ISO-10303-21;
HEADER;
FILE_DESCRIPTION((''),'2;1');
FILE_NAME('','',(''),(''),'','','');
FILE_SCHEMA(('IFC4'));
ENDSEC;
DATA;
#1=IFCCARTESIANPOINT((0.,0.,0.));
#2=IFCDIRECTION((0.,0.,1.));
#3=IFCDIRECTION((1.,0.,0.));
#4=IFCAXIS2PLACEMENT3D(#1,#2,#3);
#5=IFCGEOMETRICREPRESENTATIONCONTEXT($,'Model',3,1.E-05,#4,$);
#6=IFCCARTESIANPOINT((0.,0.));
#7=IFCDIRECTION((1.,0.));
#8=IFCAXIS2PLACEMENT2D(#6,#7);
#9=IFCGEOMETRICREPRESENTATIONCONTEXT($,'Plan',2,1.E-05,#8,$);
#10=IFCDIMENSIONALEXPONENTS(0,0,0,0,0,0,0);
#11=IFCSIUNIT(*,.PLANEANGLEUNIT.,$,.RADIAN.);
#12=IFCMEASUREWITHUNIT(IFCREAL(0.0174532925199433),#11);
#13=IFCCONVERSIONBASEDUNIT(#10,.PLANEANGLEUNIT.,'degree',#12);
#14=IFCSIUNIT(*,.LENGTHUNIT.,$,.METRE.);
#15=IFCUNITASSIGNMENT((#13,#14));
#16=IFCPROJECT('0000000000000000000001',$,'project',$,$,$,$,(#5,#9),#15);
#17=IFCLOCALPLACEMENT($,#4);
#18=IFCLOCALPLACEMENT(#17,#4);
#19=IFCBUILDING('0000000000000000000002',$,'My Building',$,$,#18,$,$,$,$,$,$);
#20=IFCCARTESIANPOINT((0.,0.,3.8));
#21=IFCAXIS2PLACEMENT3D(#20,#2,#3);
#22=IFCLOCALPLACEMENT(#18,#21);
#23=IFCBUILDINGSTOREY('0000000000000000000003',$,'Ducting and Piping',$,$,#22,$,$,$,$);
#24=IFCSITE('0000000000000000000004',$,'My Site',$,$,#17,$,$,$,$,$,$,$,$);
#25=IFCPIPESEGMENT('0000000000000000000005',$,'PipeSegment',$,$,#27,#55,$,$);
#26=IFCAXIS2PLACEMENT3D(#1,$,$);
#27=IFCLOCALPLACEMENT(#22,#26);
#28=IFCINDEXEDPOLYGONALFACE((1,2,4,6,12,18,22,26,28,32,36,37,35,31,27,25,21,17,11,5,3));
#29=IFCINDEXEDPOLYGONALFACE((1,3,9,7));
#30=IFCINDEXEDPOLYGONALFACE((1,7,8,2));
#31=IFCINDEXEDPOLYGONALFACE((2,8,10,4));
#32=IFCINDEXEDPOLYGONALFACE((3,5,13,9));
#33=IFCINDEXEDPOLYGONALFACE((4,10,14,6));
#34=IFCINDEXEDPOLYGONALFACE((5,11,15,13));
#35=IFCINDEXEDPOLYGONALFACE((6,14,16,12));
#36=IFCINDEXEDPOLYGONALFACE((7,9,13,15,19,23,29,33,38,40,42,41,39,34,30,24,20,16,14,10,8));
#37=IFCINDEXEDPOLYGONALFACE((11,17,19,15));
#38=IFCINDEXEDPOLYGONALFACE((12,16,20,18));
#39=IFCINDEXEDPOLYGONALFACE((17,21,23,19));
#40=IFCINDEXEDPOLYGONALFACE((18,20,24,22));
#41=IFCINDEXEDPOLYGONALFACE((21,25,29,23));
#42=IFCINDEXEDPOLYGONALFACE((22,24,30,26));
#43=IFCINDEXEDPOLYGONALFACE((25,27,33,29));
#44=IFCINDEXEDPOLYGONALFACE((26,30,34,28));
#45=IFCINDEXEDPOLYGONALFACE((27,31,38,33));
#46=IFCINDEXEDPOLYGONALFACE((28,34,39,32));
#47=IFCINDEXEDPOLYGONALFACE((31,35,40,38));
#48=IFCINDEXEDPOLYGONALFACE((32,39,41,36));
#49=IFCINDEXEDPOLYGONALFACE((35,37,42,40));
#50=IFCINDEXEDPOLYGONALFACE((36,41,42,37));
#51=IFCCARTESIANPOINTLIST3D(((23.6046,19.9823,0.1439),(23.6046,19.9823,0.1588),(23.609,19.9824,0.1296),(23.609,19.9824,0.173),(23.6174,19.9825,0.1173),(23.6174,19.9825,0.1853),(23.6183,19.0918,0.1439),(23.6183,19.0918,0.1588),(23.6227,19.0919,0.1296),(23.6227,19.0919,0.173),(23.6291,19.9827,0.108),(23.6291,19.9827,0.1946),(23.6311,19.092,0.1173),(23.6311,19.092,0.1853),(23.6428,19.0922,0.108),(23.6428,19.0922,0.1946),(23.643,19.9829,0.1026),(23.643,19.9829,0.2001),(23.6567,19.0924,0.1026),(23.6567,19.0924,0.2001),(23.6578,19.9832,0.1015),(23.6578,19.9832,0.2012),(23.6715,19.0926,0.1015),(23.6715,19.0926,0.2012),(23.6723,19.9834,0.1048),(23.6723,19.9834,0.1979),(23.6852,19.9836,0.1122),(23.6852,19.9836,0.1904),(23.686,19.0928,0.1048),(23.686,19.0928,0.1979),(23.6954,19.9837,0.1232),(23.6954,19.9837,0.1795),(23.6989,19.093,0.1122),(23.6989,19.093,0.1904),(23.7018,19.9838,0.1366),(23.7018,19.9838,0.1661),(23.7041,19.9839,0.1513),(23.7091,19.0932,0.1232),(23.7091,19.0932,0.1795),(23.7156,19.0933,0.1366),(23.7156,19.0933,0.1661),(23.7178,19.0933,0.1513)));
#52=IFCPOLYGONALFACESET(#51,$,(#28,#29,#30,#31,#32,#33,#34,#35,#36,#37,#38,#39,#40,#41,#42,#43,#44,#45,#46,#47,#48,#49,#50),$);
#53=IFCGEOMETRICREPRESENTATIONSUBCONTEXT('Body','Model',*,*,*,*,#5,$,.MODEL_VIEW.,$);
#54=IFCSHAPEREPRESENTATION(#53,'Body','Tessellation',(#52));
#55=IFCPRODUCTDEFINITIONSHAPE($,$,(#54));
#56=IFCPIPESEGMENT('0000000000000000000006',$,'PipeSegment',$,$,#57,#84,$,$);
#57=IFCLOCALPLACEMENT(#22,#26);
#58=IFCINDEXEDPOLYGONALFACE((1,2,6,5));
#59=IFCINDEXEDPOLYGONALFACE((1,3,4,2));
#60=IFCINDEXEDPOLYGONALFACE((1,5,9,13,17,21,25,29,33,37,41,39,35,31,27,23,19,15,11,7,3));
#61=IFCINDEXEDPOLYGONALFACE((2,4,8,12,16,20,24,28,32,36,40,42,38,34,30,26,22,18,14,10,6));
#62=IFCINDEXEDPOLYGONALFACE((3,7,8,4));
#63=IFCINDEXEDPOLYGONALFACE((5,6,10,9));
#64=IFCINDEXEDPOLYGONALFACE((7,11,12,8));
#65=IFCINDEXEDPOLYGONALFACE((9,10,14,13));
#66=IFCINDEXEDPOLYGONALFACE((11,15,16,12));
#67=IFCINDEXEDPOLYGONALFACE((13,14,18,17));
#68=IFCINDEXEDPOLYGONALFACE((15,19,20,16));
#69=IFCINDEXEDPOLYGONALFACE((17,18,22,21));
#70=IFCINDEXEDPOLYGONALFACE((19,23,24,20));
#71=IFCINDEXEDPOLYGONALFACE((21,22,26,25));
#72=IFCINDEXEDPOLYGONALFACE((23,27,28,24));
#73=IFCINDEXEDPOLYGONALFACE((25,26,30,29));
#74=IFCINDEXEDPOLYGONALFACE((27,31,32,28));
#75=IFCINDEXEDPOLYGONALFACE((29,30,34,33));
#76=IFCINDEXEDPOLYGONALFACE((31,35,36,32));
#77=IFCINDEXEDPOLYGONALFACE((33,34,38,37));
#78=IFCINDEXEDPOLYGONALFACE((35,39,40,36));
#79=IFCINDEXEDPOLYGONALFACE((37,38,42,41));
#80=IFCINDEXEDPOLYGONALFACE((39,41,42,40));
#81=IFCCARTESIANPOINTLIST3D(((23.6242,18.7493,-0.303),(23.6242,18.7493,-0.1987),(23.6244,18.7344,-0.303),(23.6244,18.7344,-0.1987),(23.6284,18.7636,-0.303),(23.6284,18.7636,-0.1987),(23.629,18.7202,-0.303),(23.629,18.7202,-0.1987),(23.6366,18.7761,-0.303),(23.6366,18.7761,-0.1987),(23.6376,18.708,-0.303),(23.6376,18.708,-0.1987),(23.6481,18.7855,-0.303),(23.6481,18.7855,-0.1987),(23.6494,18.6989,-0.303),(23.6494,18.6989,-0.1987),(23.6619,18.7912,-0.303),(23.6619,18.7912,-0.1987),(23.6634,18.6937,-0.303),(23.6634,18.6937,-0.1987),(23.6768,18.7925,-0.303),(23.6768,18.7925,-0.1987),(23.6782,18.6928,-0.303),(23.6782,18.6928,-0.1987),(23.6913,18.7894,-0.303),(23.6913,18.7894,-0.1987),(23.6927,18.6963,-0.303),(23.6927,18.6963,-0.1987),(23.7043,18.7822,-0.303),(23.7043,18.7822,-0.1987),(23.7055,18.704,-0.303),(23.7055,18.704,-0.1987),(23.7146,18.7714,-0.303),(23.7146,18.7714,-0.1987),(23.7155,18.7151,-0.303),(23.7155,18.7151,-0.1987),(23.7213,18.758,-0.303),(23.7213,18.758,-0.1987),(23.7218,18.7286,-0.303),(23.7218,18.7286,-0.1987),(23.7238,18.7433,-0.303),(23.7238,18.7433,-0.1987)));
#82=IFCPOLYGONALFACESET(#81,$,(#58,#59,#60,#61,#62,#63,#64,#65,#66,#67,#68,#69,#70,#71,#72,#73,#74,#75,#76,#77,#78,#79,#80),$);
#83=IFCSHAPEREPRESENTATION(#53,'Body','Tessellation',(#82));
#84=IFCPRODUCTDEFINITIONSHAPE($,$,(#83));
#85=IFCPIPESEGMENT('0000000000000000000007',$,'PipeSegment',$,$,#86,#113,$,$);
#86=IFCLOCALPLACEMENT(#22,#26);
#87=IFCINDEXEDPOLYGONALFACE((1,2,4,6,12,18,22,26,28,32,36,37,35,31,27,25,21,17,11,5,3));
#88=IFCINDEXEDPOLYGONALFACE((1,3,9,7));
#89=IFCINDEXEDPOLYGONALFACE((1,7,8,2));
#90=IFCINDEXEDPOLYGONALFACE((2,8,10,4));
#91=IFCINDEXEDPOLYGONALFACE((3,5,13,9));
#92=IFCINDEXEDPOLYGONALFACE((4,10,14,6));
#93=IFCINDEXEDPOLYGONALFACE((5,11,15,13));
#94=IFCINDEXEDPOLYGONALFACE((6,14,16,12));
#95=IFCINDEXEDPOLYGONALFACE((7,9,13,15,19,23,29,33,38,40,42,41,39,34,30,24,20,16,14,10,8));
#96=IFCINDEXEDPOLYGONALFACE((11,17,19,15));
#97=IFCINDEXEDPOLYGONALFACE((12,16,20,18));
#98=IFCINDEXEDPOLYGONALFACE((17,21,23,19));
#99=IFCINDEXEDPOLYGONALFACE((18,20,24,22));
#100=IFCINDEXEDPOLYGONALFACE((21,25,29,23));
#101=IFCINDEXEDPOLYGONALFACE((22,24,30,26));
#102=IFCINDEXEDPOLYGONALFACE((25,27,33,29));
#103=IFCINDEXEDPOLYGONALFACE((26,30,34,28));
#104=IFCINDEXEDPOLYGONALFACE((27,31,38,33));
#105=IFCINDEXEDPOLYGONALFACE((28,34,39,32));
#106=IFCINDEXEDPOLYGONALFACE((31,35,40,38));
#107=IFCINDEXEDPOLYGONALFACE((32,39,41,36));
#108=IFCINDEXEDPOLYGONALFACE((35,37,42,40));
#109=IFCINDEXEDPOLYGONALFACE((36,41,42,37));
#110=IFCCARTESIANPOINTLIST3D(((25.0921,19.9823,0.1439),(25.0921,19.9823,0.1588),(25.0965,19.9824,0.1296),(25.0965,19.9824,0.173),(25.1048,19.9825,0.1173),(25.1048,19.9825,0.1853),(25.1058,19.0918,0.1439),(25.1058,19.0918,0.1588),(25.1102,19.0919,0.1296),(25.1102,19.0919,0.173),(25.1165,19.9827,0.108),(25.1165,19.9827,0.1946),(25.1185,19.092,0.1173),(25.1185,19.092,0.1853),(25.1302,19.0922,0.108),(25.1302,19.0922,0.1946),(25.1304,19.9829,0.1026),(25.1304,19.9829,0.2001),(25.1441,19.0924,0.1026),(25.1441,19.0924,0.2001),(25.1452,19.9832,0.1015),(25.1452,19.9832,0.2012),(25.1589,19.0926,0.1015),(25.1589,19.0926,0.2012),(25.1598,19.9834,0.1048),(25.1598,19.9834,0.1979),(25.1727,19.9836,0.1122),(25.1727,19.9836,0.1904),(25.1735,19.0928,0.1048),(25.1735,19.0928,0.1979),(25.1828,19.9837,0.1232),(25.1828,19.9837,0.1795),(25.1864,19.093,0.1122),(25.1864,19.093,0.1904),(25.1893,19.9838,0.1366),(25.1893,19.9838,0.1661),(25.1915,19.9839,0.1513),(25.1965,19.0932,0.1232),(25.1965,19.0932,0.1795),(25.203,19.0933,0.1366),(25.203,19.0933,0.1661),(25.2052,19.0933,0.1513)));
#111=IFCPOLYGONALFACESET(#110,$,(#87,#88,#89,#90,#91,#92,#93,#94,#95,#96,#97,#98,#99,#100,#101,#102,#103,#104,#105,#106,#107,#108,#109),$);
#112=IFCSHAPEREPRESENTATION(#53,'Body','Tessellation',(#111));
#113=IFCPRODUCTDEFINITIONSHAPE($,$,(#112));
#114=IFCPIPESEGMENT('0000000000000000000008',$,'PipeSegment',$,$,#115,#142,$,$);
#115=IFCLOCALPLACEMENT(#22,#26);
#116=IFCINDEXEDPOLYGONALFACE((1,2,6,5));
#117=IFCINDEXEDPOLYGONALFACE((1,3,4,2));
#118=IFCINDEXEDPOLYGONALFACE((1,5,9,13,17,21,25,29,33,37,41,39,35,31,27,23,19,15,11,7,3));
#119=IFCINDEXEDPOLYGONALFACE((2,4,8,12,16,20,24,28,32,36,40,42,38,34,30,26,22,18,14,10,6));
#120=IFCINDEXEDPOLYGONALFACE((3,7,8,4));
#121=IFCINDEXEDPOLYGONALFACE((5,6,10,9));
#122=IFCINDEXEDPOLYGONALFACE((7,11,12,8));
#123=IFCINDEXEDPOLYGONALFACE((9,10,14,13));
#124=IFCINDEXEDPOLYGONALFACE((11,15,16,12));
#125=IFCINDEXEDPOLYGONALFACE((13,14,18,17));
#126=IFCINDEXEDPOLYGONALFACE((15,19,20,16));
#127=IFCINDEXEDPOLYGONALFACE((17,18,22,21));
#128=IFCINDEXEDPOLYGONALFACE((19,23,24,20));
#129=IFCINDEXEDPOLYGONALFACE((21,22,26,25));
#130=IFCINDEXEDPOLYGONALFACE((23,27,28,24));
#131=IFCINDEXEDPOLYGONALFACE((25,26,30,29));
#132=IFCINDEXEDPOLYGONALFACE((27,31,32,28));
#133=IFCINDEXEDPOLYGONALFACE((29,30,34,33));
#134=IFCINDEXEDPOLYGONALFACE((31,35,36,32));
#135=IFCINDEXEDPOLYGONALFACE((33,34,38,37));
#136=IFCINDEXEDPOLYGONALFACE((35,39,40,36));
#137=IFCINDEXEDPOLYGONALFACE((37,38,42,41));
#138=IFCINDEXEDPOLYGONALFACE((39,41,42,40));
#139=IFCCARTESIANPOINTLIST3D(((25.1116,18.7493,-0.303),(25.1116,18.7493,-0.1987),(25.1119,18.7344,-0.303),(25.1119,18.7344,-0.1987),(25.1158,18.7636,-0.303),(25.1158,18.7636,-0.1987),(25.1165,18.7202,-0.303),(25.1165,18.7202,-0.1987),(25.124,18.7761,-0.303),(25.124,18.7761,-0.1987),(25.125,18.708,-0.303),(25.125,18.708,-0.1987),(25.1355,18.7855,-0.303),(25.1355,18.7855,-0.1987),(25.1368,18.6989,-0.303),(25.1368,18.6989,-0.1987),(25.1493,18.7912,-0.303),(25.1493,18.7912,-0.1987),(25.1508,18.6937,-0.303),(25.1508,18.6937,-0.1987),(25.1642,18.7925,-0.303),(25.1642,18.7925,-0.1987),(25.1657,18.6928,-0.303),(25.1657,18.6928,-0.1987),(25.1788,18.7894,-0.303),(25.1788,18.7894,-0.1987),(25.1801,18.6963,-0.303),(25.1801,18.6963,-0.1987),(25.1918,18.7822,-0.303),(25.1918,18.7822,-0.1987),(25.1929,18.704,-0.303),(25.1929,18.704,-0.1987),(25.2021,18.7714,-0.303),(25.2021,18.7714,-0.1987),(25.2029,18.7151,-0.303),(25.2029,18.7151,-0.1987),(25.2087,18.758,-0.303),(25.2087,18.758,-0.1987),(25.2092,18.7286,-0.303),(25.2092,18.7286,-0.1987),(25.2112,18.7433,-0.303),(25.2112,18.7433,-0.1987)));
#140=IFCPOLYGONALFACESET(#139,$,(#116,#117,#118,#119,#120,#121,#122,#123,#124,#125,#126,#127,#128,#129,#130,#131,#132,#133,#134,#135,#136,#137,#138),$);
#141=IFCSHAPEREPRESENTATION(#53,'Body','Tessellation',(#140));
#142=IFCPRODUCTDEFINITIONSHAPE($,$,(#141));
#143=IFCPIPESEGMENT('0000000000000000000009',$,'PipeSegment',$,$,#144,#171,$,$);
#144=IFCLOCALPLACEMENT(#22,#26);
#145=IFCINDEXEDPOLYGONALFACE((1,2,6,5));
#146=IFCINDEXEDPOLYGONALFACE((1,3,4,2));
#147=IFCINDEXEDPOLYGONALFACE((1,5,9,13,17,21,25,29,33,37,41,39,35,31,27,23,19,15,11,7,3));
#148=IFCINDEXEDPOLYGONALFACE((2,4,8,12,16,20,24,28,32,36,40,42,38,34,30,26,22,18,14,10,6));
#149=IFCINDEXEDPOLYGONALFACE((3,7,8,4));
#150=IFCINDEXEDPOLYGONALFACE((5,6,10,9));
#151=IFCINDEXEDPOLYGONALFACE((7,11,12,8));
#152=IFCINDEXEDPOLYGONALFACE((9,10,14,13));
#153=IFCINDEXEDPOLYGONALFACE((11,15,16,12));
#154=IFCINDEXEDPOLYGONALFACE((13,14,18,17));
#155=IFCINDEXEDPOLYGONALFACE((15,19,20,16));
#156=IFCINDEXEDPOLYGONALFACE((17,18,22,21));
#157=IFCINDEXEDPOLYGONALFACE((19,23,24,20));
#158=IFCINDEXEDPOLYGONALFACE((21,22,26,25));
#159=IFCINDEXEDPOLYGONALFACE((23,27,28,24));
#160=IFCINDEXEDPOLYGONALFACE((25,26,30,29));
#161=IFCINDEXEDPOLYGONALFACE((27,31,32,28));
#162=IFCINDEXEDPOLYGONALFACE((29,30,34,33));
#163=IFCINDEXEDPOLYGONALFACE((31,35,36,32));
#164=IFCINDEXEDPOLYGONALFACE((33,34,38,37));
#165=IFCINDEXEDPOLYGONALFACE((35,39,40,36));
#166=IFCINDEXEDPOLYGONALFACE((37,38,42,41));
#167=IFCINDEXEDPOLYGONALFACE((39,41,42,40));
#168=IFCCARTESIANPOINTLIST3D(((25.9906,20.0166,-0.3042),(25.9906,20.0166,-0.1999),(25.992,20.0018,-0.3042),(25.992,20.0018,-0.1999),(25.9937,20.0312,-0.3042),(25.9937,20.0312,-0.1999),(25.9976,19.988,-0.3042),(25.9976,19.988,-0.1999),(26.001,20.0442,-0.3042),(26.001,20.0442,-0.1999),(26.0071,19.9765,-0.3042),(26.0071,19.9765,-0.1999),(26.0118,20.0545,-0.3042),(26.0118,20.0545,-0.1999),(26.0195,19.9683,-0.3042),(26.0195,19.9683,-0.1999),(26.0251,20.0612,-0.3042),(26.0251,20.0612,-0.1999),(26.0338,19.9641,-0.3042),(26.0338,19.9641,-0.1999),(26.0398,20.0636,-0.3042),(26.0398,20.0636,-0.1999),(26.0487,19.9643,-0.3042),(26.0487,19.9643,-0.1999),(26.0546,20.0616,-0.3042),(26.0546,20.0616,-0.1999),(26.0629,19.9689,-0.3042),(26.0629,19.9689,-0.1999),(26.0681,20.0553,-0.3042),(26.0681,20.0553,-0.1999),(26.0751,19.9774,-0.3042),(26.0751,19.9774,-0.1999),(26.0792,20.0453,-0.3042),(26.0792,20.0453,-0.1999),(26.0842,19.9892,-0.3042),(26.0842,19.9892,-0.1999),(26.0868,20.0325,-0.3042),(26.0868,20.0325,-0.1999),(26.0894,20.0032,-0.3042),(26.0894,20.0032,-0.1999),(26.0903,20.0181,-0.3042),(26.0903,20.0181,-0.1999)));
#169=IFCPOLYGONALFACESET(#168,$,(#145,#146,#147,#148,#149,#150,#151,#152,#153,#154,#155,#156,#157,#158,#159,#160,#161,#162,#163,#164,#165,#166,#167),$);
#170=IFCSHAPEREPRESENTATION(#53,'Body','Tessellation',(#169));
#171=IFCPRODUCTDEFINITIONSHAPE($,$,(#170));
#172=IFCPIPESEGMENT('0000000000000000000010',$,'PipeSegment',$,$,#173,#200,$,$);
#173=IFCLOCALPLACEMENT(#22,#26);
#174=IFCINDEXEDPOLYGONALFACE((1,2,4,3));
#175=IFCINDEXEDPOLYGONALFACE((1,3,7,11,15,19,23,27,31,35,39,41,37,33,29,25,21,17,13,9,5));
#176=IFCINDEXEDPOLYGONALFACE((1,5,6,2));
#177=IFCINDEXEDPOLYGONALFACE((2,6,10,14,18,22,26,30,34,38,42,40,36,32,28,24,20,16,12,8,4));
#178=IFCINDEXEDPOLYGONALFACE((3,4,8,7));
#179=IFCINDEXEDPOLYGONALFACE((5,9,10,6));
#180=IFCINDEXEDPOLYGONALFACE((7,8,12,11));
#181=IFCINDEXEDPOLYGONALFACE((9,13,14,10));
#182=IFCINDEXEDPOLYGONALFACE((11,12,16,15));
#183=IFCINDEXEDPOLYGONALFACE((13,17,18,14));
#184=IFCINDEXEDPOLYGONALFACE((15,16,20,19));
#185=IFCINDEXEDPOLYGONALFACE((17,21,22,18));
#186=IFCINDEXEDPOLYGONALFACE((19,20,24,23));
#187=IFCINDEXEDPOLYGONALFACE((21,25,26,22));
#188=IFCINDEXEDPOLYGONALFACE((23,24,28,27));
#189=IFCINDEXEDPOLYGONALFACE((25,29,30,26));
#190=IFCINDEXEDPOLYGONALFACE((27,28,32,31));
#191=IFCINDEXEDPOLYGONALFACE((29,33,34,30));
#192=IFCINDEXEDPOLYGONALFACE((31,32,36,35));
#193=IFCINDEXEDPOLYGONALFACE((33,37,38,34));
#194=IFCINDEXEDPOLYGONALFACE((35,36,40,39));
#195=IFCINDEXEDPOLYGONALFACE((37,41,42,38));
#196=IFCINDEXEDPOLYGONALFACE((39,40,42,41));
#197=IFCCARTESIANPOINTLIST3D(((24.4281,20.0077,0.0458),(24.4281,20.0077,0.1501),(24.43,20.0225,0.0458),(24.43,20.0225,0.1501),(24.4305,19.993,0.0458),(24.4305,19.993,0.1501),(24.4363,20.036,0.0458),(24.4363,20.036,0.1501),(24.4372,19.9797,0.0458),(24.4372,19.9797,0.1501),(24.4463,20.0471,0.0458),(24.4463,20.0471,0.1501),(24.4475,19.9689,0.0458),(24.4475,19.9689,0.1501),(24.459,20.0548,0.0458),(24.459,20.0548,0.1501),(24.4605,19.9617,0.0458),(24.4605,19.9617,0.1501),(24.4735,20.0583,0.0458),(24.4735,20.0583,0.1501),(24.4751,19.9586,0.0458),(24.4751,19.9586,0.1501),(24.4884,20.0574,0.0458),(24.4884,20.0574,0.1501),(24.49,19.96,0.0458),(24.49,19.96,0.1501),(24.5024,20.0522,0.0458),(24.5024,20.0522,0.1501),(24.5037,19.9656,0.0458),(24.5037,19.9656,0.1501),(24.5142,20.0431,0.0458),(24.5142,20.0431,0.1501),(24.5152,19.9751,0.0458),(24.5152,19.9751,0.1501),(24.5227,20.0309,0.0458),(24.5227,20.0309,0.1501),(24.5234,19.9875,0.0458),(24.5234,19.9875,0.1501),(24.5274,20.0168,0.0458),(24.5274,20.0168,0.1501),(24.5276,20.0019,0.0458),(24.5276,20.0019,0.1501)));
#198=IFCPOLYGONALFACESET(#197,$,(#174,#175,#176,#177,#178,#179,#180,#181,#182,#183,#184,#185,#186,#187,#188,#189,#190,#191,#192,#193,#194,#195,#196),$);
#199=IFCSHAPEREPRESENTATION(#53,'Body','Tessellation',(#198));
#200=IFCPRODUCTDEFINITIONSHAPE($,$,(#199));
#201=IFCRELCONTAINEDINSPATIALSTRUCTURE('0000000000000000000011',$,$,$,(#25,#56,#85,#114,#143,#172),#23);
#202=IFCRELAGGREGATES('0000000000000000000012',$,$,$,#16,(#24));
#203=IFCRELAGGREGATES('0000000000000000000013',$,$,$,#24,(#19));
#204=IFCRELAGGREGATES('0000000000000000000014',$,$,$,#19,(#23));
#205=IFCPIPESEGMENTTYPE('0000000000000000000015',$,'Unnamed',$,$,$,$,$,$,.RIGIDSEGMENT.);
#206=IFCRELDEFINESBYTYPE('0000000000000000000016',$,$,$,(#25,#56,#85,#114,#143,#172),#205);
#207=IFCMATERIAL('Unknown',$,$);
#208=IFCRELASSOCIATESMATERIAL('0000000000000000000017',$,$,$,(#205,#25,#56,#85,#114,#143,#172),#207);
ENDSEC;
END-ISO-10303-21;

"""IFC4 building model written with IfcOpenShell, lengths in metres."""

from ifc_helpers import new_model, entity, si_unit, converted_unit, frame, origin_with_axes, origin_2d_with_axis, place, context, subcontext, project, spatial, circle, extrude, material, material_profile, profile_set, profile_usage, type_object, element, save


model = new_model("IFC4")

# Units and contexts
model_context = context("Model", 3, precision=1e-05, world=origin_with_axes())
plan_context = context("Plan", 2, precision=1e-05, world=origin_2d_with_axis())
body_context = subcontext(model_context, "Body", "Model", "MODEL_VIEW")
ifc_project = project(units=[converted_unit("PLANEANGLEUNIT", "degree", entity("IfcReal", 0.0174532925199433), si_unit("PLANEANGLEUNIT", "RADIAN"), dimensions=[0, 0, 0, 0, 0, 0, 0]), si_unit("LENGTHUNIT", "METRE")], contexts=[model_context, plan_context])

# Site, building, storey
site_placement = place(None, origin_with_axes())
site = spatial("IfcSite", under=ifc_project, at=site_placement, Name="My Site")
building_placement = place(site_placement, origin_with_axes())
building = spatial("IfcBuilding", under=site, at=building_placement, Name="My Building")
storey_placement = place(building_placement, frame((0.0, 0.0, 3.8), z_axis=(0.0, 0.0, 1.0), x_axis=(1.0, 0.0, 0.0)))
storey = spatial("IfcBuildingStorey", under=building, at=storey_placement, Name="Ducting and Piping")

# Pipe segments
ifc_material = material(Name="Unknown")
ifc_material_profile_1 = material_profile(ifc_material, circle(Radius=0.05))
ifc_profile_set_1 = profile_set([ifc_material_profile_1])
pipe_segment_type = type_object("IfcPipeSegmentType", Name="Unnamed", PredefinedType="RIGIDSEGMENT", material=ifc_profile_set_1)
ifc_profile_usage_1 = profile_usage(ifc_profile_set_1, cardinal=5)
pipe_segment_1_placement = place(storey_placement, frame((23.6541, 19.9831, 0.1513), z_axis=(0.015385, -0.999882, 0.0), x_axis=(0.999882, 0.015385, 0.0)))
element("IfcPipeSegment", 1, at=pipe_segment_1_placement, inside=storey, type_object=pipe_segment_type, material=ifc_profile_usage_1, Name="PipeSegment", context=body_context, shape_type="SweptSolid", body=[
    extrude(circle(Radius=0.05), origin_with_axes(), (0.0, 0.0, 1.0), 0.8907),
])
ifc_profile_usage_2 = profile_usage(ifc_profile_set_1, cardinal=5)
pipe_segment_2_placement = place(storey_placement, frame((23.6738, 18.7426, -0.303), z_axis=(0.0, 0.0, 1.0), x_axis=(0.999889, 0.014879, 0.0)))
element("IfcPipeSegment", 2, at=pipe_segment_2_placement, inside=storey, type_object=pipe_segment_type, material=ifc_profile_usage_2, Name="PipeSegment", context=body_context, shape_type="SweptSolid", body=[
    extrude(circle(Radius=0.05), origin_with_axes(), (0.0, 0.0, 1.0), 0.1043),
])
ifc_profile_usage_3 = profile_usage(ifc_profile_set_1, cardinal=5)
pipe_segment_3_placement = place(storey_placement, frame((25.1415, 19.9831, 0.1513), z_axis=(0.015385, -0.999882, 0.0), x_axis=(0.999882, 0.015385, 0.0)))
element("IfcPipeSegment", 3, at=pipe_segment_3_placement, inside=storey, type_object=pipe_segment_type, material=ifc_profile_usage_3, Name="PipeSegment", context=body_context, shape_type="SweptSolid", body=[
    extrude(circle(Radius=0.05), origin_with_axes(), (0.0, 0.0, 1.0), 0.8907),
])
ifc_profile_usage_4 = profile_usage(ifc_profile_set_1, cardinal=5)
pipe_segment_4_placement = place(storey_placement, frame((25.1612, 18.7426, -0.303), z_axis=(0.0, 0.0, 1.0), x_axis=(0.999889, 0.014879, 0.0)))
element("IfcPipeSegment", 4, at=pipe_segment_4_placement, inside=storey, type_object=pipe_segment_type, material=ifc_profile_usage_4, Name="PipeSegment", context=body_context, shape_type="SweptSolid", body=[
    extrude(circle(Radius=0.05), origin_with_axes(), (0.0, 0.0, 1.0), 0.1043),
])
ifc_profile_usage_5 = profile_usage(ifc_profile_set_1, cardinal=5)
pipe_segment_5_placement = place(storey_placement, frame((26.0405, 20.0136, -0.3042), z_axis=(0.0, 0.0, 1.0), x_axis=(-0.014266, 0.999898, 0.0)))
element("IfcPipeSegment", 5, at=pipe_segment_5_placement, inside=storey, type_object=pipe_segment_type, material=ifc_profile_usage_5, Name="PipeSegment", context=body_context, shape_type="SweptSolid", body=[
    extrude(circle(Radius=0.05), origin_with_axes(), (0.0, 0.0, 1.0), 0.1043),
])
ifc_profile_usage_6 = profile_usage(ifc_profile_set_1, cardinal=5)
pipe_segment_6_placement = place(storey_placement, frame((24.4781, 20.0085, 0.0458), z_axis=(0.0, 0.0, 1.0), x_axis=(-0.999873, -0.015924, 0.0)))
element("IfcPipeSegment", 6, at=pipe_segment_6_placement, inside=storey, type_object=pipe_segment_type, material=ifc_profile_usage_6, Name="PipeSegment", context=body_context, shape_type="SweptSolid", body=[
    extrude(circle(Radius=0.05), origin_with_axes(), (0.0, 0.0, 1.0), 0.1043),
])

save(model, "model.ifc")
